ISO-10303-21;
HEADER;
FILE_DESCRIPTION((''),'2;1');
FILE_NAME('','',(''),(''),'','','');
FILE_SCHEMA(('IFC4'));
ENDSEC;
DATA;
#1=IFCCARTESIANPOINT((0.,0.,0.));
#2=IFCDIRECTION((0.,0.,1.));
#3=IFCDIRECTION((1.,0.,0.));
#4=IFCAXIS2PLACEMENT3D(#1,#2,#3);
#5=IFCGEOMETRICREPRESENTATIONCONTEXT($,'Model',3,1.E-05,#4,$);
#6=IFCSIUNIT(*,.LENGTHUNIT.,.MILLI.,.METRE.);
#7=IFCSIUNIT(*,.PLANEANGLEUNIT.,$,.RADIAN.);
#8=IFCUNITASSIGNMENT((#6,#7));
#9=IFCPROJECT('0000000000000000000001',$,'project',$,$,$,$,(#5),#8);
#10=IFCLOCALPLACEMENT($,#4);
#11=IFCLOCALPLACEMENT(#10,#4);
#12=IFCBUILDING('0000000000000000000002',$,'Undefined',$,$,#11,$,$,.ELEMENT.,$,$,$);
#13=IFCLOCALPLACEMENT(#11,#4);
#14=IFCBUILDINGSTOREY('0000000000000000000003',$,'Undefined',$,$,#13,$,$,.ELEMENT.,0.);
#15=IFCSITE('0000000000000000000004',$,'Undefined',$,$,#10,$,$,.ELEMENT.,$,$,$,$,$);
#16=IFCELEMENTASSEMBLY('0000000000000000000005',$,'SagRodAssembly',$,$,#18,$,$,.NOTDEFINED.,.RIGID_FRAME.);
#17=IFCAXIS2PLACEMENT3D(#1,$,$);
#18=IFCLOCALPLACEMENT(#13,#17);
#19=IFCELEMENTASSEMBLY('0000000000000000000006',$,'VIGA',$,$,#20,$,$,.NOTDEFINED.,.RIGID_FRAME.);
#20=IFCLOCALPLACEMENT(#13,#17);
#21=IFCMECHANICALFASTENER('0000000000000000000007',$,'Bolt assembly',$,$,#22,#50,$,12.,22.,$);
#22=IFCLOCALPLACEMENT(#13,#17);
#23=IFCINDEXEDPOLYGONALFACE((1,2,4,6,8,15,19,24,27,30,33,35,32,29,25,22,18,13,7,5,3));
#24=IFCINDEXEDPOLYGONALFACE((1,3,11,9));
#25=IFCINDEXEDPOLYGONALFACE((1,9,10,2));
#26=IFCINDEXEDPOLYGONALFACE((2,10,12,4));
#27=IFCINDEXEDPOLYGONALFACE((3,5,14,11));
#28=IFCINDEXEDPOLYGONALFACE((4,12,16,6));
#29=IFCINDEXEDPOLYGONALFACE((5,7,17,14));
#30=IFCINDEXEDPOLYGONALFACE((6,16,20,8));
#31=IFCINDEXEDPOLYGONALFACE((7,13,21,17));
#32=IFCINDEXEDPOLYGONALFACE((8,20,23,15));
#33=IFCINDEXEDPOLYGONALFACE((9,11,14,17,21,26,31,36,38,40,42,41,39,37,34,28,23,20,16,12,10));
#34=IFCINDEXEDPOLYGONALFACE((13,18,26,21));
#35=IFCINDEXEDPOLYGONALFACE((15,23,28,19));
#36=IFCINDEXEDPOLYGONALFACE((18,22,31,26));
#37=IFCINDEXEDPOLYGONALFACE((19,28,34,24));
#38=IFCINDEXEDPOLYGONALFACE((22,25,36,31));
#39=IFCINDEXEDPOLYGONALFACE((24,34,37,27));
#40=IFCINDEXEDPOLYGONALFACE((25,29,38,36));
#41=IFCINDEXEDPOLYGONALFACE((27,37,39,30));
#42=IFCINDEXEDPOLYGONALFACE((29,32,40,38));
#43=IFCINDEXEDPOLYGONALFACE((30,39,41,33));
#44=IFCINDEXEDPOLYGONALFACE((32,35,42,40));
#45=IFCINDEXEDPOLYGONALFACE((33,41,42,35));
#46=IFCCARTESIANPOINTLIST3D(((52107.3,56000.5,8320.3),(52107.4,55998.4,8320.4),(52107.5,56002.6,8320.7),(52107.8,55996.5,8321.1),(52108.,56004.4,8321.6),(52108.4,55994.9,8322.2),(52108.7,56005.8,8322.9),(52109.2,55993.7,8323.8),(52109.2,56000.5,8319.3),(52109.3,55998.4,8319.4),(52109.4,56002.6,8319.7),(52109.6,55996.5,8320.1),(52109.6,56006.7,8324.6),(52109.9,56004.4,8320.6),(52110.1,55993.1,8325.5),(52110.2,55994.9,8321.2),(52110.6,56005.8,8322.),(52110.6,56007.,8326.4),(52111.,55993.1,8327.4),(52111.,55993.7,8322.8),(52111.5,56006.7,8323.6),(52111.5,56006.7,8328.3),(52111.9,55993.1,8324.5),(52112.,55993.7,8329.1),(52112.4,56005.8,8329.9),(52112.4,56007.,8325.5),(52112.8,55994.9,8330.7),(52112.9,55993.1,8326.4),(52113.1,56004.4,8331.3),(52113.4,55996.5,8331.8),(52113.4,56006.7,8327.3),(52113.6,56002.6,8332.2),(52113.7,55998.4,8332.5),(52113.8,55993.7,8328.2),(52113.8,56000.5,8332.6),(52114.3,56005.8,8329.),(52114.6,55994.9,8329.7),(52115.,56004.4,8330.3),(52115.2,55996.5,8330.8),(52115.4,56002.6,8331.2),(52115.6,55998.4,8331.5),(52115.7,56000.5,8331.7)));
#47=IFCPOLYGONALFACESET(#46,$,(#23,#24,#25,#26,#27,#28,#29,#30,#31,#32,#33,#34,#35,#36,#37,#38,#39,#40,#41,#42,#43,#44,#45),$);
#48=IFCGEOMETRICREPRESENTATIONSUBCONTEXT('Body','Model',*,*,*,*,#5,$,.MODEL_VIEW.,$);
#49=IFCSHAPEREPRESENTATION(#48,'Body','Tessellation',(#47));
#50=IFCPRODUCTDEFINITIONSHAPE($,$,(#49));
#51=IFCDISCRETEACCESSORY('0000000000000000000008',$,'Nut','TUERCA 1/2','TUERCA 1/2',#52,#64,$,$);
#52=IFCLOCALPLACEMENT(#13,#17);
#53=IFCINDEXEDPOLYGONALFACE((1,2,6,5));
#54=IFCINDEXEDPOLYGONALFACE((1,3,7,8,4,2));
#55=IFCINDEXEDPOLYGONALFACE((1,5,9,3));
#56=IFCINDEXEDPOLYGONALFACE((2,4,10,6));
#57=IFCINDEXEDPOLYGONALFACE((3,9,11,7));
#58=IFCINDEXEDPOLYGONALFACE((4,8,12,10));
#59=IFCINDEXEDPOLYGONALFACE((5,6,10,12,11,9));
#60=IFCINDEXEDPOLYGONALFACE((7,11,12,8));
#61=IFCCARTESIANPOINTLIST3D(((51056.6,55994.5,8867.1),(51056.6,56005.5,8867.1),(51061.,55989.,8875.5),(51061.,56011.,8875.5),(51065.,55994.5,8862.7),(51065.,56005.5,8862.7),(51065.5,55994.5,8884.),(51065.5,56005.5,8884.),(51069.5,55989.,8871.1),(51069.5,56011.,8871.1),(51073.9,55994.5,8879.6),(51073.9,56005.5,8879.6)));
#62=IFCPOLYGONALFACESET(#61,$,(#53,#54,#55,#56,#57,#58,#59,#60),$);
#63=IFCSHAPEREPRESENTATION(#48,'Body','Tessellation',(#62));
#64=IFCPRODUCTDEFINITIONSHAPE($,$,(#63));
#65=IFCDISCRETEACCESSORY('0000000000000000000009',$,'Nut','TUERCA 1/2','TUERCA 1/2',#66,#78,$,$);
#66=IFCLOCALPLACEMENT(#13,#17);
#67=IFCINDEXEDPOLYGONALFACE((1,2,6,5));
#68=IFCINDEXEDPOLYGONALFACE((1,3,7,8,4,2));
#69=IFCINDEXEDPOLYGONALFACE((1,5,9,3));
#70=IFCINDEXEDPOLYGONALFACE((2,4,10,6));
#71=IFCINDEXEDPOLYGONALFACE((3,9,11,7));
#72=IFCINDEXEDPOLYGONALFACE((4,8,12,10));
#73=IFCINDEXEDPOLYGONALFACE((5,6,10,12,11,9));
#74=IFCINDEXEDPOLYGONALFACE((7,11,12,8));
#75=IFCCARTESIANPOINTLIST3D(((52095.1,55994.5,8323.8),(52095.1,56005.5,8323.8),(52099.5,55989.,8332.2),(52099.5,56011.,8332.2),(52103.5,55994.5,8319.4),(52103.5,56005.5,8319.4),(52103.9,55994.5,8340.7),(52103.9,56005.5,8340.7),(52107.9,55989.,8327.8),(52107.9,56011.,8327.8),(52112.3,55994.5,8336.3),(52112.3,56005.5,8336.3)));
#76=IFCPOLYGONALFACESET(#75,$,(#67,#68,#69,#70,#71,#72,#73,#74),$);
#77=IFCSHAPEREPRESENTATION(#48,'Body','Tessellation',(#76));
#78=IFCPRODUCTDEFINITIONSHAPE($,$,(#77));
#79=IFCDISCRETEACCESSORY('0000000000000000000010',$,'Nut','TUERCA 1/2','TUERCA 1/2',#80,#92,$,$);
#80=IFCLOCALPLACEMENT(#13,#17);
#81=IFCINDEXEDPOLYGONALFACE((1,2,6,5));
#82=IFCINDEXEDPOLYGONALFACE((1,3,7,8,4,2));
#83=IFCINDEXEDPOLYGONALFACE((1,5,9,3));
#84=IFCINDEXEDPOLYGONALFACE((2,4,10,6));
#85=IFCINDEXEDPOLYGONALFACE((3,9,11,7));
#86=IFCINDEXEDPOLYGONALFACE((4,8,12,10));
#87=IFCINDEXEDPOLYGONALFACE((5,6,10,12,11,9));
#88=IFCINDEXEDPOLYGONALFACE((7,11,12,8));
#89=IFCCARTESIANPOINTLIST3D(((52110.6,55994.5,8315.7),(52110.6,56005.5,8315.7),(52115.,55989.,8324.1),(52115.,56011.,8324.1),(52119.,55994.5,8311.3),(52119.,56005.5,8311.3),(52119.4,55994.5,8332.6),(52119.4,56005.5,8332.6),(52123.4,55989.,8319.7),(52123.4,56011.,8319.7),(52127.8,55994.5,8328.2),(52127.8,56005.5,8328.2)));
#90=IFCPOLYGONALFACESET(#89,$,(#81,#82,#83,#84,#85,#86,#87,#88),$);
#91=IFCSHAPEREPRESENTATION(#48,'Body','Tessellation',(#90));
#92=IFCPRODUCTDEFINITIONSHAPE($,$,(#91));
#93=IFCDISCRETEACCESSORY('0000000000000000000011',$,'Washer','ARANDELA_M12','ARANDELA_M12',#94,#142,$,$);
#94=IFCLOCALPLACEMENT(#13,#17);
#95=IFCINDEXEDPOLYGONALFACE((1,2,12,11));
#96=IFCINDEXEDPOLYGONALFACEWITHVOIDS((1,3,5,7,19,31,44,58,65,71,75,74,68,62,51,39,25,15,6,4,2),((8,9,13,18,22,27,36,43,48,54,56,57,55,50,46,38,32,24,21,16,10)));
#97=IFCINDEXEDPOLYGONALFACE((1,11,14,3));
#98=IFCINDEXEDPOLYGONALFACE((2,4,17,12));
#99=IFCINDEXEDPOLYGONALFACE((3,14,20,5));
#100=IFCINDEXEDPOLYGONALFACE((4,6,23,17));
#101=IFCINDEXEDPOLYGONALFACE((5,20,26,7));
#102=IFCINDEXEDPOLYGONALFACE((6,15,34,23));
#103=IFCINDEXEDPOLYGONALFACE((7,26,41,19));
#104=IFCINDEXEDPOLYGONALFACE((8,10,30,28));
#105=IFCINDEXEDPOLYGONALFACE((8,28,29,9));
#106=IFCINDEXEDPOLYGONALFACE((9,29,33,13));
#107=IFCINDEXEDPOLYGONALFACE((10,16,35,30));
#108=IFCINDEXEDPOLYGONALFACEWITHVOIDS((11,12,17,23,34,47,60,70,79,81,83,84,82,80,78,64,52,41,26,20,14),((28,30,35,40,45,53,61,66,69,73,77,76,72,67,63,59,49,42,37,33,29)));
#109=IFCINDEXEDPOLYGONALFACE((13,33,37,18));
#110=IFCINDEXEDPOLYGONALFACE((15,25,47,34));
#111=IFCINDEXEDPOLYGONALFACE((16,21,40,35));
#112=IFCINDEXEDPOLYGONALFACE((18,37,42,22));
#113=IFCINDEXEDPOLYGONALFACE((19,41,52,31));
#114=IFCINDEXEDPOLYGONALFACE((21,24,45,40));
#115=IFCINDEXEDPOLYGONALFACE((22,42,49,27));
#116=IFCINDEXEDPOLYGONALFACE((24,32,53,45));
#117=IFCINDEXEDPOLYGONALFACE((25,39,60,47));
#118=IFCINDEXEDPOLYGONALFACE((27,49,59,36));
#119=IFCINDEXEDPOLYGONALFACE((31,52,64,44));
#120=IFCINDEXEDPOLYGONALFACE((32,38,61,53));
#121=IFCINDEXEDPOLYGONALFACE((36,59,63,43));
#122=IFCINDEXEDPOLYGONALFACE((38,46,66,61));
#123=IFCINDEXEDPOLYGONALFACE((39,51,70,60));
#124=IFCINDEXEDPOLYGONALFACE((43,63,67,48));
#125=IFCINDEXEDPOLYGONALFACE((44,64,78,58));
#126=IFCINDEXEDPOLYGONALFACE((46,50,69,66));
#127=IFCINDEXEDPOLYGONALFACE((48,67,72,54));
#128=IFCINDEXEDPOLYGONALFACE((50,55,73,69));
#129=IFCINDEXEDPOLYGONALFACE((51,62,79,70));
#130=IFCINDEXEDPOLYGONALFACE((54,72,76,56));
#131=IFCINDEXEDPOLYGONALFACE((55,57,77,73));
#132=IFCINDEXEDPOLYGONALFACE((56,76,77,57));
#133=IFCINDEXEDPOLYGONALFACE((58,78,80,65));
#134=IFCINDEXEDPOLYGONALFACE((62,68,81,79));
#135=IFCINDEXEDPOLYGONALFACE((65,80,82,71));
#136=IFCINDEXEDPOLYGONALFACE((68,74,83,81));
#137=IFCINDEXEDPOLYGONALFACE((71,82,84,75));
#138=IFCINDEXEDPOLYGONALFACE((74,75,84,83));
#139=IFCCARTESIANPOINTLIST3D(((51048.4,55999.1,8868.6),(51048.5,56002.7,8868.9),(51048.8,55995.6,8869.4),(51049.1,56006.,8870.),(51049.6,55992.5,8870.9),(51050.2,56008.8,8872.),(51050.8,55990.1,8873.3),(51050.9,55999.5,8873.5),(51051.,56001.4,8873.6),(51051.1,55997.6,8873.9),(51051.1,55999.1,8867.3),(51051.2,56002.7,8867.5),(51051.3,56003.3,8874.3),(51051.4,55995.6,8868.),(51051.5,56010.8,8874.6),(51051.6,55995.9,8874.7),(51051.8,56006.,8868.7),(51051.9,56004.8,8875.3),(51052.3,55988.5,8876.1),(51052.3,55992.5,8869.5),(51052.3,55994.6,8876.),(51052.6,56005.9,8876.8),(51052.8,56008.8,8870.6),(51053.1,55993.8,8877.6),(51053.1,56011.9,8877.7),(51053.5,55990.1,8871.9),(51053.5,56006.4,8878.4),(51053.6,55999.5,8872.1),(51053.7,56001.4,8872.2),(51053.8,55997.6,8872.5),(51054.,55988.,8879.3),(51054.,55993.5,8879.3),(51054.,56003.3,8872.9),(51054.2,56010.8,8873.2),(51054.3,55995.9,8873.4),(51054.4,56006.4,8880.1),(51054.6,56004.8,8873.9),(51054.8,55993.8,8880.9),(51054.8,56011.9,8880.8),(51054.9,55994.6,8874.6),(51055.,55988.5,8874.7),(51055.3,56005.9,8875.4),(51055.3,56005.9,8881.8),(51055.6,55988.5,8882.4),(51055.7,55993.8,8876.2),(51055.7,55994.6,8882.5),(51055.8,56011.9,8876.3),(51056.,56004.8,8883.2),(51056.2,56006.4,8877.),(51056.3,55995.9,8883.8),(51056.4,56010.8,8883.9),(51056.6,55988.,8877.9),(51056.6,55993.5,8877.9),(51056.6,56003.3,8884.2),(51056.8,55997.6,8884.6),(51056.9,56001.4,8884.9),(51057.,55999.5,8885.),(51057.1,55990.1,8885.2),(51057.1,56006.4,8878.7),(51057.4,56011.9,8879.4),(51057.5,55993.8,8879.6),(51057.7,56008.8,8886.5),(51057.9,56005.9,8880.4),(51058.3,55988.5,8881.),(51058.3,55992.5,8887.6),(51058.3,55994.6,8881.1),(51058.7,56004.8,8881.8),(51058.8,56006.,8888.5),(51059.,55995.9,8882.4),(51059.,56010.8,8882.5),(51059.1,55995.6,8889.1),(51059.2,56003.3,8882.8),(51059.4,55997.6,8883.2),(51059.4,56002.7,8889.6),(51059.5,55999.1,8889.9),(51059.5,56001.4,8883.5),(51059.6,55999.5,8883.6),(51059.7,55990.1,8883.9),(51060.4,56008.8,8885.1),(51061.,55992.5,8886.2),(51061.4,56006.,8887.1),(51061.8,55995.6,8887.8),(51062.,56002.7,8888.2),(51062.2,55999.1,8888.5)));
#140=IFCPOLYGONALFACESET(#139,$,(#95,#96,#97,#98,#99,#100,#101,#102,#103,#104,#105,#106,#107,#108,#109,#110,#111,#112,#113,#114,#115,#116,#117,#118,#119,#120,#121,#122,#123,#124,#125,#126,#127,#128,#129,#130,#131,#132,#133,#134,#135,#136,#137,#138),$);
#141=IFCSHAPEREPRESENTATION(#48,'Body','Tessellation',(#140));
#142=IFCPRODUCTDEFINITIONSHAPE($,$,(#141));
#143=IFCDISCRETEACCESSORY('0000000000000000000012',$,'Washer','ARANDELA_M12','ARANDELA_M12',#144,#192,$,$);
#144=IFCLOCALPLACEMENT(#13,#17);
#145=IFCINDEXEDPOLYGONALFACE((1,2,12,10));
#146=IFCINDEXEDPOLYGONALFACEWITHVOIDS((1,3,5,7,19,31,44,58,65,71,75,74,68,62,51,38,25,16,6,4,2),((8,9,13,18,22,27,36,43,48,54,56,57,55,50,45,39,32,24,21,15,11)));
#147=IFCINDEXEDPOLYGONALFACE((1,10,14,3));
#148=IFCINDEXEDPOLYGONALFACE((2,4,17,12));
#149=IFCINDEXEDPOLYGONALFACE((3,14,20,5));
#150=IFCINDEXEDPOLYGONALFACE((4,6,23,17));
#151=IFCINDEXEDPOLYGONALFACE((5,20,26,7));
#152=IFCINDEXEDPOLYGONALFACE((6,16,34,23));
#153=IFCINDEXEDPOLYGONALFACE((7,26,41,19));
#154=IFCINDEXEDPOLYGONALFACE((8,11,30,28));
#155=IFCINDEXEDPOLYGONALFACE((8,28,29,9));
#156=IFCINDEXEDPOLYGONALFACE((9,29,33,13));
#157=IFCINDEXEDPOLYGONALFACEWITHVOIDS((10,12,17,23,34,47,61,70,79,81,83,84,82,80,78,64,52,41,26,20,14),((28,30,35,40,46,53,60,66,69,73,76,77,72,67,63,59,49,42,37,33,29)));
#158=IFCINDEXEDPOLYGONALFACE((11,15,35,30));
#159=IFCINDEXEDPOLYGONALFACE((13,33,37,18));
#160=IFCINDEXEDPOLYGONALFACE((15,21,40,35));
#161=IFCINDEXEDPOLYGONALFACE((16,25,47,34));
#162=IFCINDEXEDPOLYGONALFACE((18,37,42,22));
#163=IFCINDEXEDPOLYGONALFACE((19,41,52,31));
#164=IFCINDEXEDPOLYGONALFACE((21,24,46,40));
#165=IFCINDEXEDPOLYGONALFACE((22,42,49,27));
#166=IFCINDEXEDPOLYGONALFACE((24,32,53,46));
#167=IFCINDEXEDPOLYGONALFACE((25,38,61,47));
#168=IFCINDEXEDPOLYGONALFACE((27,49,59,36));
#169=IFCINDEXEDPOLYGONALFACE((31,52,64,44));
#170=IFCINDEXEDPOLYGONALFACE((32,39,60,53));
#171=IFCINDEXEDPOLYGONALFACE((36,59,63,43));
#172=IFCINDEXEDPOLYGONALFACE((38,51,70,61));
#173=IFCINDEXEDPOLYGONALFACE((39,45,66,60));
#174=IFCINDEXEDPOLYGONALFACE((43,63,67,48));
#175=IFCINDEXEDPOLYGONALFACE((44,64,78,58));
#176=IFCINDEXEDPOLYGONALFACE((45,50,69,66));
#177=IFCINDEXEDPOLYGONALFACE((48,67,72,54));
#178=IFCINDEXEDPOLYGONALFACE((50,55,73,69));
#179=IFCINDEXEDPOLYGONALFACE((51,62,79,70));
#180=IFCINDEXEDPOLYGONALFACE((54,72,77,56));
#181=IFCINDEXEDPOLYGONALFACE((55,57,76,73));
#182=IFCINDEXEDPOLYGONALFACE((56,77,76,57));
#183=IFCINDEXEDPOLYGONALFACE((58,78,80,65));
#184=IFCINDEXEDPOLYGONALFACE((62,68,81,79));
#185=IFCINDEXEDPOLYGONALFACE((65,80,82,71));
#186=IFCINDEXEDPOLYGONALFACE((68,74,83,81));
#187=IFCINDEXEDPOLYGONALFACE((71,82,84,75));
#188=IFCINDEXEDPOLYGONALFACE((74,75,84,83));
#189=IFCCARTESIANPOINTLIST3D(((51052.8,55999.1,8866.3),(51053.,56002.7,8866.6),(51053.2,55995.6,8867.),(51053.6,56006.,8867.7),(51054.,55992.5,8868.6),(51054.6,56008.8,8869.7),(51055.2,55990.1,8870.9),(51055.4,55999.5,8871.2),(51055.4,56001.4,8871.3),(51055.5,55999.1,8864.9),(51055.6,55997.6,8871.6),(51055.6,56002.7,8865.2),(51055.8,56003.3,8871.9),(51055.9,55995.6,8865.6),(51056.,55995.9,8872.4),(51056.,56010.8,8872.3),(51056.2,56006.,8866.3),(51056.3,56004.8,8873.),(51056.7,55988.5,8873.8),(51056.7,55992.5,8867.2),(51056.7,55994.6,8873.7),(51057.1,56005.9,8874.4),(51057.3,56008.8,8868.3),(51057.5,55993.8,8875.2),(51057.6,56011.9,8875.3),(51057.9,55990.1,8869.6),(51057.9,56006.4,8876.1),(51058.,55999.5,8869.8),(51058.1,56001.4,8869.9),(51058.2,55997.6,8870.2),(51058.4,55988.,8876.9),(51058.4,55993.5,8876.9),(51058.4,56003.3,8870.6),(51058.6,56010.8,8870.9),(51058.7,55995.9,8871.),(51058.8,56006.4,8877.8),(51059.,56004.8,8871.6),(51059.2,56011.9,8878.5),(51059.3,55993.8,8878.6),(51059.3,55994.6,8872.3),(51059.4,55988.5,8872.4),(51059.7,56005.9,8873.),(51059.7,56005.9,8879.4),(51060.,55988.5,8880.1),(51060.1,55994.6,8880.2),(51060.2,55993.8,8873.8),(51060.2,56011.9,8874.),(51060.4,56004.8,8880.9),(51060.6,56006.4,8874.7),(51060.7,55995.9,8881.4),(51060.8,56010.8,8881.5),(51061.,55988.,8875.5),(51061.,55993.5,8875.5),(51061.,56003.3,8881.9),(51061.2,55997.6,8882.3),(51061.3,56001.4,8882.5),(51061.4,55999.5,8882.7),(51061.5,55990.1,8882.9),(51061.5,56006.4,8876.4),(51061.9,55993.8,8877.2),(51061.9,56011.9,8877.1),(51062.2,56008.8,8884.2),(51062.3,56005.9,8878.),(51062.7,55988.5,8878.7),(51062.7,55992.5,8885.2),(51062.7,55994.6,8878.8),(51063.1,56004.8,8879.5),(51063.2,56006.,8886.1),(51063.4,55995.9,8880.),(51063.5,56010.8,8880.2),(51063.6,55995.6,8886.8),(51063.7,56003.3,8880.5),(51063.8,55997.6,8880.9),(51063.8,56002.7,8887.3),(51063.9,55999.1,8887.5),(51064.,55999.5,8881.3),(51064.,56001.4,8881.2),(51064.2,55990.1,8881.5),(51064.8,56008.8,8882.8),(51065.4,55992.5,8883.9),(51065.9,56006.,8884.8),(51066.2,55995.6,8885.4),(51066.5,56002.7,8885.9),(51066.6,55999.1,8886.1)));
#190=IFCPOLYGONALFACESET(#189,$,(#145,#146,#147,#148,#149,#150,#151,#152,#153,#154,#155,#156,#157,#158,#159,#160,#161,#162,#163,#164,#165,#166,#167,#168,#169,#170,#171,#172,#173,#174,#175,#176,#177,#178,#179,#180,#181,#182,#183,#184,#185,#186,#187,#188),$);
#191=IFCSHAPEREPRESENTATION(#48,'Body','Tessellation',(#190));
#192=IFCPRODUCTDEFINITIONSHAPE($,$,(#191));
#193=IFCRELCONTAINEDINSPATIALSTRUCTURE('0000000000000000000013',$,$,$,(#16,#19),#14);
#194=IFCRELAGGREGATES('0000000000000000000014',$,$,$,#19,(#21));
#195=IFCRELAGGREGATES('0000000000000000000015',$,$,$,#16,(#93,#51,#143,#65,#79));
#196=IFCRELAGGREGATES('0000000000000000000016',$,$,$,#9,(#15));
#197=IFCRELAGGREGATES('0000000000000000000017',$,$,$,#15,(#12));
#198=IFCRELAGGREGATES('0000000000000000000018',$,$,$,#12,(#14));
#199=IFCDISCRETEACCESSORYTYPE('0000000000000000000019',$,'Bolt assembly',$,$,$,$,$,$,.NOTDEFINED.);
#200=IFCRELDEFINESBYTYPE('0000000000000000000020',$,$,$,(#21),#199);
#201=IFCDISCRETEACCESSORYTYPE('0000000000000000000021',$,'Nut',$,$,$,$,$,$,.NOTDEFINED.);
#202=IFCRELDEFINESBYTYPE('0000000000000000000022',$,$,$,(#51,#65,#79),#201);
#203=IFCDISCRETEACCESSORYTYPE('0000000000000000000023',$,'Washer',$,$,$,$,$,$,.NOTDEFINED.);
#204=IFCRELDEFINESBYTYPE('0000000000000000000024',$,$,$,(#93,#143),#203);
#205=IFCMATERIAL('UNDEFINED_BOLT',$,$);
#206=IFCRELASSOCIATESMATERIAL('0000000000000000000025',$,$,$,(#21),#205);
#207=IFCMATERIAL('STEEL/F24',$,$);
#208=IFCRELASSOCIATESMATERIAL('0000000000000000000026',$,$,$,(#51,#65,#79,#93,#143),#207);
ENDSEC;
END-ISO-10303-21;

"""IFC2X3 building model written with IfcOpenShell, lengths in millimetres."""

from ifc_helpers import new_model, si_unit, frame, origin_with_axes, origin_2d_with_axis, place, context, subcontext, project, spatial, polyline, circle, hollow_circle, outline, extrude, source, transform, mapped, material, type_object, element, aggregate, save


model = new_model("IFC2X3")

# Units and contexts
model_context = context("Model", 3, precision=1e-05, world=origin_with_axes())
body_context = subcontext(model_context, "Body", "Model", "MODEL_VIEW")
ifc_project = project(units=[si_unit("LENGTHUNIT", "METRE", prefix="MILLI"), si_unit("PLANEANGLEUNIT", "RADIAN")], contexts=[model_context])

# Site, building, storey
site_placement = place(None, origin_with_axes())
site = spatial("IfcSite", under=ifc_project, at=site_placement, Name="Undefined", CompositionType="ELEMENT")
building_placement = place(site_placement, origin_with_axes())
building = spatial("IfcBuilding", under=site, at=building_placement, Name="Undefined", CompositionType="ELEMENT")
storey_placement = place(building_placement, origin_with_axes())
storey = spatial("IfcBuildingStorey", under=building, at=storey_placement, Name="Undefined", CompositionType="ELEMENT", Elevation=0.0)

# Shared definitions
ifc_material_1 = material(Name="STEEL/F24")

# Element assembly
assembly_1_placement = place(storey_placement, origin_with_axes())
assembly_1 = element("IfcElementAssembly", 1, at=assembly_1_placement, inside=storey, Name="SagRodAssembly", AssemblyPlace="NOTDEFINED", PredefinedType="RIGID_FRAME")

# Element assembly, mechanical fastener
ifc_material_2 = material(Name="UNDEFINED_BOLT")
discrete_accessory_type_1 = type_object("IfcDiscreteAccessoryType", Name="Bolt assembly")
shared_shape_1 = source(origin_with_axes(), body_context, "Body", "SweptSolid", [
    extrude(circle(Radius=7.0, at=origin_2d_with_axis()), frame((0.0, -1.0, 0.0), z_axis=(0.0, 1.0, 0.0), x_axis=(1.0, 0.0, 0.0)), (0.0, 0.0, 1.0), 2.1),
])
assembly_2_placement = place(storey_placement, origin_with_axes())
assembly_2 = element("IfcElementAssembly", 2, at=assembly_2_placement, inside=storey, Name="VIGA", AssemblyPlace="NOTDEFINED", PredefinedType="RIGID_FRAME")
mechanical_fastener_1_placement = place(assembly_2_placement, frame((52111.4, 56000.0, 8326.0), z_axis=(-0.463605, 0.0, -0.886042), x_axis=(0.0, 1.0, 0.0)))
mechanical_fastener_1 = element("IfcMechanicalFastener", 3, at=mechanical_fastener_1_placement, type_object=discrete_accessory_type_1, material=ifc_material_2, Name="Bolt assembly", NominalDiameter=12.0, NominalLength=22.0, context=body_context, shape_type="MappedRepresentation", body=[
    mapped(shared_shape_1, transform((0.0, 0.0, 0.0))),
])
aggregate(assembly_2, [mechanical_fastener_1])

# Discrete accessories
discrete_accessory_type_2 = type_object("IfcDiscreteAccessoryType", Name="Nut")
discrete_accessory_1_placement = place(assembly_1_placement, frame((51069.5, 56000.0, 8871.1), z_axis=(-0.463578, 0.0, -0.886056), x_axis=(-0.886056, 0.0, 0.463578)))
discrete_accessory_1 = element("IfcDiscreteAccessory", 4, at=discrete_accessory_1_placement, type_object=discrete_accessory_type_2, material=ifc_material_1, Name="Nut", Description="TUERCA 1/2", ObjectType="TUERCA 1/2", context=body_context, shape_type="SweptSolid", body=[
    extrude(outline(polyline([(-5.5, 9.5), (5.5, 9.5), (11.0, 0.0), (5.5, -9.5), (-5.5, -9.5), (-11.0, 0.0), (-5.5, 9.5)])), frame((9.5, 0.0, 0.0), z_axis=(-1.0, 0.0, 0.0), x_axis=(0.0, -1.0, 0.0)), (0.0, 0.0, 1.0), 9.5),
])
discrete_accessory_2_placement = place(assembly_1_placement, frame((52107.9, 56000.0, 8327.8), z_axis=(-0.463578, 0.0, -0.886056), x_axis=(-0.886056, 0.0, 0.463578)))
discrete_accessory_2 = element("IfcDiscreteAccessory", 5, at=discrete_accessory_2_placement, type_object=discrete_accessory_type_2, material=ifc_material_1, Name="Nut", Description="TUERCA 1/2", ObjectType="TUERCA 1/2", context=body_context, shape_type="SweptSolid", body=[
    extrude(outline(polyline([(-5.5, 9.5), (5.5, 9.5), (11.0, 0.0), (5.5, -9.5), (-5.5, -9.5), (-11.0, 0.0), (-5.5, 9.5)])), frame((9.5, 0.0, 0.0), z_axis=(-1.0, 0.0, 0.0), x_axis=(0.0, -1.0, 0.0)), (0.0, 0.0, 1.0), 9.5),
])
discrete_accessory_3_placement = place(assembly_1_placement, frame((52123.4, 56000.0, 8319.7), z_axis=(-0.463578, 0.0, -0.886056), x_axis=(-0.886056, 0.0, 0.463578)))
discrete_accessory_3 = element("IfcDiscreteAccessory", 6, at=discrete_accessory_3_placement, type_object=discrete_accessory_type_2, material=ifc_material_1, Name="Nut", Description="TUERCA 1/2", ObjectType="TUERCA 1/2", context=body_context, shape_type="SweptSolid", body=[
    extrude(outline(polyline([(-5.5, 9.5), (5.5, 9.5), (11.0, 0.0), (5.5, -9.5), (-5.5, -9.5), (-11.0, 0.0), (-5.5, 9.5)])), frame((9.5, 0.0, 0.0), z_axis=(-1.0, 0.0, 0.0), x_axis=(0.0, -1.0, 0.0)), (0.0, 0.0, 1.0), 9.5),
])
discrete_accessory_type_3 = type_object("IfcDiscreteAccessoryType", Name="Washer")
discrete_accessory_4_placement = place(assembly_1_placement, frame((51056.6, 56000.0, 8877.9), z_axis=(-0.463578, 0.0, -0.886056), x_axis=(-0.886056, 0.0, 0.463578)))
discrete_accessory_4 = element("IfcDiscreteAccessory", 7, at=discrete_accessory_4_placement, type_object=discrete_accessory_type_3, material=ifc_material_1, Name="Washer", Description="ARANDELA_M12", ObjectType="ARANDELA_M12", context=body_context, shape_type="SweptSolid", body=[
    extrude(hollow_circle(Radius=12.0, WallThickness=5.5, at=origin_2d_with_axis()), frame((3.0, 0.0, 0.0), z_axis=(-1.0, 0.0, 0.0), x_axis=(0.0, -1.0, 0.0)), (0.0, 0.0, 1.0), 3.0),
])
discrete_accessory_5_placement = place(assembly_1_placement, frame((51061.0, 56000.0, 8875.5), z_axis=(-0.463578, 0.0, -0.886056), x_axis=(-0.886056, 0.0, 0.463578)))
discrete_accessory_5 = element("IfcDiscreteAccessory", 8, at=discrete_accessory_5_placement, type_object=discrete_accessory_type_3, material=ifc_material_1, Name="Washer", Description="ARANDELA_M12", ObjectType="ARANDELA_M12", context=body_context, shape_type="SweptSolid", body=[
    extrude(hollow_circle(Radius=12.0, WallThickness=5.5, at=origin_2d_with_axis()), frame((3.0, 0.0, 0.0), z_axis=(-1.0, 0.0, 0.0), x_axis=(0.0, -1.0, 0.0)), (0.0, 0.0, 1.0), 3.0),
])
aggregate(assembly_1, [discrete_accessory_4, discrete_accessory_1, discrete_accessory_5, discrete_accessory_2, discrete_accessory_3])

save(model, "model.ifc")
